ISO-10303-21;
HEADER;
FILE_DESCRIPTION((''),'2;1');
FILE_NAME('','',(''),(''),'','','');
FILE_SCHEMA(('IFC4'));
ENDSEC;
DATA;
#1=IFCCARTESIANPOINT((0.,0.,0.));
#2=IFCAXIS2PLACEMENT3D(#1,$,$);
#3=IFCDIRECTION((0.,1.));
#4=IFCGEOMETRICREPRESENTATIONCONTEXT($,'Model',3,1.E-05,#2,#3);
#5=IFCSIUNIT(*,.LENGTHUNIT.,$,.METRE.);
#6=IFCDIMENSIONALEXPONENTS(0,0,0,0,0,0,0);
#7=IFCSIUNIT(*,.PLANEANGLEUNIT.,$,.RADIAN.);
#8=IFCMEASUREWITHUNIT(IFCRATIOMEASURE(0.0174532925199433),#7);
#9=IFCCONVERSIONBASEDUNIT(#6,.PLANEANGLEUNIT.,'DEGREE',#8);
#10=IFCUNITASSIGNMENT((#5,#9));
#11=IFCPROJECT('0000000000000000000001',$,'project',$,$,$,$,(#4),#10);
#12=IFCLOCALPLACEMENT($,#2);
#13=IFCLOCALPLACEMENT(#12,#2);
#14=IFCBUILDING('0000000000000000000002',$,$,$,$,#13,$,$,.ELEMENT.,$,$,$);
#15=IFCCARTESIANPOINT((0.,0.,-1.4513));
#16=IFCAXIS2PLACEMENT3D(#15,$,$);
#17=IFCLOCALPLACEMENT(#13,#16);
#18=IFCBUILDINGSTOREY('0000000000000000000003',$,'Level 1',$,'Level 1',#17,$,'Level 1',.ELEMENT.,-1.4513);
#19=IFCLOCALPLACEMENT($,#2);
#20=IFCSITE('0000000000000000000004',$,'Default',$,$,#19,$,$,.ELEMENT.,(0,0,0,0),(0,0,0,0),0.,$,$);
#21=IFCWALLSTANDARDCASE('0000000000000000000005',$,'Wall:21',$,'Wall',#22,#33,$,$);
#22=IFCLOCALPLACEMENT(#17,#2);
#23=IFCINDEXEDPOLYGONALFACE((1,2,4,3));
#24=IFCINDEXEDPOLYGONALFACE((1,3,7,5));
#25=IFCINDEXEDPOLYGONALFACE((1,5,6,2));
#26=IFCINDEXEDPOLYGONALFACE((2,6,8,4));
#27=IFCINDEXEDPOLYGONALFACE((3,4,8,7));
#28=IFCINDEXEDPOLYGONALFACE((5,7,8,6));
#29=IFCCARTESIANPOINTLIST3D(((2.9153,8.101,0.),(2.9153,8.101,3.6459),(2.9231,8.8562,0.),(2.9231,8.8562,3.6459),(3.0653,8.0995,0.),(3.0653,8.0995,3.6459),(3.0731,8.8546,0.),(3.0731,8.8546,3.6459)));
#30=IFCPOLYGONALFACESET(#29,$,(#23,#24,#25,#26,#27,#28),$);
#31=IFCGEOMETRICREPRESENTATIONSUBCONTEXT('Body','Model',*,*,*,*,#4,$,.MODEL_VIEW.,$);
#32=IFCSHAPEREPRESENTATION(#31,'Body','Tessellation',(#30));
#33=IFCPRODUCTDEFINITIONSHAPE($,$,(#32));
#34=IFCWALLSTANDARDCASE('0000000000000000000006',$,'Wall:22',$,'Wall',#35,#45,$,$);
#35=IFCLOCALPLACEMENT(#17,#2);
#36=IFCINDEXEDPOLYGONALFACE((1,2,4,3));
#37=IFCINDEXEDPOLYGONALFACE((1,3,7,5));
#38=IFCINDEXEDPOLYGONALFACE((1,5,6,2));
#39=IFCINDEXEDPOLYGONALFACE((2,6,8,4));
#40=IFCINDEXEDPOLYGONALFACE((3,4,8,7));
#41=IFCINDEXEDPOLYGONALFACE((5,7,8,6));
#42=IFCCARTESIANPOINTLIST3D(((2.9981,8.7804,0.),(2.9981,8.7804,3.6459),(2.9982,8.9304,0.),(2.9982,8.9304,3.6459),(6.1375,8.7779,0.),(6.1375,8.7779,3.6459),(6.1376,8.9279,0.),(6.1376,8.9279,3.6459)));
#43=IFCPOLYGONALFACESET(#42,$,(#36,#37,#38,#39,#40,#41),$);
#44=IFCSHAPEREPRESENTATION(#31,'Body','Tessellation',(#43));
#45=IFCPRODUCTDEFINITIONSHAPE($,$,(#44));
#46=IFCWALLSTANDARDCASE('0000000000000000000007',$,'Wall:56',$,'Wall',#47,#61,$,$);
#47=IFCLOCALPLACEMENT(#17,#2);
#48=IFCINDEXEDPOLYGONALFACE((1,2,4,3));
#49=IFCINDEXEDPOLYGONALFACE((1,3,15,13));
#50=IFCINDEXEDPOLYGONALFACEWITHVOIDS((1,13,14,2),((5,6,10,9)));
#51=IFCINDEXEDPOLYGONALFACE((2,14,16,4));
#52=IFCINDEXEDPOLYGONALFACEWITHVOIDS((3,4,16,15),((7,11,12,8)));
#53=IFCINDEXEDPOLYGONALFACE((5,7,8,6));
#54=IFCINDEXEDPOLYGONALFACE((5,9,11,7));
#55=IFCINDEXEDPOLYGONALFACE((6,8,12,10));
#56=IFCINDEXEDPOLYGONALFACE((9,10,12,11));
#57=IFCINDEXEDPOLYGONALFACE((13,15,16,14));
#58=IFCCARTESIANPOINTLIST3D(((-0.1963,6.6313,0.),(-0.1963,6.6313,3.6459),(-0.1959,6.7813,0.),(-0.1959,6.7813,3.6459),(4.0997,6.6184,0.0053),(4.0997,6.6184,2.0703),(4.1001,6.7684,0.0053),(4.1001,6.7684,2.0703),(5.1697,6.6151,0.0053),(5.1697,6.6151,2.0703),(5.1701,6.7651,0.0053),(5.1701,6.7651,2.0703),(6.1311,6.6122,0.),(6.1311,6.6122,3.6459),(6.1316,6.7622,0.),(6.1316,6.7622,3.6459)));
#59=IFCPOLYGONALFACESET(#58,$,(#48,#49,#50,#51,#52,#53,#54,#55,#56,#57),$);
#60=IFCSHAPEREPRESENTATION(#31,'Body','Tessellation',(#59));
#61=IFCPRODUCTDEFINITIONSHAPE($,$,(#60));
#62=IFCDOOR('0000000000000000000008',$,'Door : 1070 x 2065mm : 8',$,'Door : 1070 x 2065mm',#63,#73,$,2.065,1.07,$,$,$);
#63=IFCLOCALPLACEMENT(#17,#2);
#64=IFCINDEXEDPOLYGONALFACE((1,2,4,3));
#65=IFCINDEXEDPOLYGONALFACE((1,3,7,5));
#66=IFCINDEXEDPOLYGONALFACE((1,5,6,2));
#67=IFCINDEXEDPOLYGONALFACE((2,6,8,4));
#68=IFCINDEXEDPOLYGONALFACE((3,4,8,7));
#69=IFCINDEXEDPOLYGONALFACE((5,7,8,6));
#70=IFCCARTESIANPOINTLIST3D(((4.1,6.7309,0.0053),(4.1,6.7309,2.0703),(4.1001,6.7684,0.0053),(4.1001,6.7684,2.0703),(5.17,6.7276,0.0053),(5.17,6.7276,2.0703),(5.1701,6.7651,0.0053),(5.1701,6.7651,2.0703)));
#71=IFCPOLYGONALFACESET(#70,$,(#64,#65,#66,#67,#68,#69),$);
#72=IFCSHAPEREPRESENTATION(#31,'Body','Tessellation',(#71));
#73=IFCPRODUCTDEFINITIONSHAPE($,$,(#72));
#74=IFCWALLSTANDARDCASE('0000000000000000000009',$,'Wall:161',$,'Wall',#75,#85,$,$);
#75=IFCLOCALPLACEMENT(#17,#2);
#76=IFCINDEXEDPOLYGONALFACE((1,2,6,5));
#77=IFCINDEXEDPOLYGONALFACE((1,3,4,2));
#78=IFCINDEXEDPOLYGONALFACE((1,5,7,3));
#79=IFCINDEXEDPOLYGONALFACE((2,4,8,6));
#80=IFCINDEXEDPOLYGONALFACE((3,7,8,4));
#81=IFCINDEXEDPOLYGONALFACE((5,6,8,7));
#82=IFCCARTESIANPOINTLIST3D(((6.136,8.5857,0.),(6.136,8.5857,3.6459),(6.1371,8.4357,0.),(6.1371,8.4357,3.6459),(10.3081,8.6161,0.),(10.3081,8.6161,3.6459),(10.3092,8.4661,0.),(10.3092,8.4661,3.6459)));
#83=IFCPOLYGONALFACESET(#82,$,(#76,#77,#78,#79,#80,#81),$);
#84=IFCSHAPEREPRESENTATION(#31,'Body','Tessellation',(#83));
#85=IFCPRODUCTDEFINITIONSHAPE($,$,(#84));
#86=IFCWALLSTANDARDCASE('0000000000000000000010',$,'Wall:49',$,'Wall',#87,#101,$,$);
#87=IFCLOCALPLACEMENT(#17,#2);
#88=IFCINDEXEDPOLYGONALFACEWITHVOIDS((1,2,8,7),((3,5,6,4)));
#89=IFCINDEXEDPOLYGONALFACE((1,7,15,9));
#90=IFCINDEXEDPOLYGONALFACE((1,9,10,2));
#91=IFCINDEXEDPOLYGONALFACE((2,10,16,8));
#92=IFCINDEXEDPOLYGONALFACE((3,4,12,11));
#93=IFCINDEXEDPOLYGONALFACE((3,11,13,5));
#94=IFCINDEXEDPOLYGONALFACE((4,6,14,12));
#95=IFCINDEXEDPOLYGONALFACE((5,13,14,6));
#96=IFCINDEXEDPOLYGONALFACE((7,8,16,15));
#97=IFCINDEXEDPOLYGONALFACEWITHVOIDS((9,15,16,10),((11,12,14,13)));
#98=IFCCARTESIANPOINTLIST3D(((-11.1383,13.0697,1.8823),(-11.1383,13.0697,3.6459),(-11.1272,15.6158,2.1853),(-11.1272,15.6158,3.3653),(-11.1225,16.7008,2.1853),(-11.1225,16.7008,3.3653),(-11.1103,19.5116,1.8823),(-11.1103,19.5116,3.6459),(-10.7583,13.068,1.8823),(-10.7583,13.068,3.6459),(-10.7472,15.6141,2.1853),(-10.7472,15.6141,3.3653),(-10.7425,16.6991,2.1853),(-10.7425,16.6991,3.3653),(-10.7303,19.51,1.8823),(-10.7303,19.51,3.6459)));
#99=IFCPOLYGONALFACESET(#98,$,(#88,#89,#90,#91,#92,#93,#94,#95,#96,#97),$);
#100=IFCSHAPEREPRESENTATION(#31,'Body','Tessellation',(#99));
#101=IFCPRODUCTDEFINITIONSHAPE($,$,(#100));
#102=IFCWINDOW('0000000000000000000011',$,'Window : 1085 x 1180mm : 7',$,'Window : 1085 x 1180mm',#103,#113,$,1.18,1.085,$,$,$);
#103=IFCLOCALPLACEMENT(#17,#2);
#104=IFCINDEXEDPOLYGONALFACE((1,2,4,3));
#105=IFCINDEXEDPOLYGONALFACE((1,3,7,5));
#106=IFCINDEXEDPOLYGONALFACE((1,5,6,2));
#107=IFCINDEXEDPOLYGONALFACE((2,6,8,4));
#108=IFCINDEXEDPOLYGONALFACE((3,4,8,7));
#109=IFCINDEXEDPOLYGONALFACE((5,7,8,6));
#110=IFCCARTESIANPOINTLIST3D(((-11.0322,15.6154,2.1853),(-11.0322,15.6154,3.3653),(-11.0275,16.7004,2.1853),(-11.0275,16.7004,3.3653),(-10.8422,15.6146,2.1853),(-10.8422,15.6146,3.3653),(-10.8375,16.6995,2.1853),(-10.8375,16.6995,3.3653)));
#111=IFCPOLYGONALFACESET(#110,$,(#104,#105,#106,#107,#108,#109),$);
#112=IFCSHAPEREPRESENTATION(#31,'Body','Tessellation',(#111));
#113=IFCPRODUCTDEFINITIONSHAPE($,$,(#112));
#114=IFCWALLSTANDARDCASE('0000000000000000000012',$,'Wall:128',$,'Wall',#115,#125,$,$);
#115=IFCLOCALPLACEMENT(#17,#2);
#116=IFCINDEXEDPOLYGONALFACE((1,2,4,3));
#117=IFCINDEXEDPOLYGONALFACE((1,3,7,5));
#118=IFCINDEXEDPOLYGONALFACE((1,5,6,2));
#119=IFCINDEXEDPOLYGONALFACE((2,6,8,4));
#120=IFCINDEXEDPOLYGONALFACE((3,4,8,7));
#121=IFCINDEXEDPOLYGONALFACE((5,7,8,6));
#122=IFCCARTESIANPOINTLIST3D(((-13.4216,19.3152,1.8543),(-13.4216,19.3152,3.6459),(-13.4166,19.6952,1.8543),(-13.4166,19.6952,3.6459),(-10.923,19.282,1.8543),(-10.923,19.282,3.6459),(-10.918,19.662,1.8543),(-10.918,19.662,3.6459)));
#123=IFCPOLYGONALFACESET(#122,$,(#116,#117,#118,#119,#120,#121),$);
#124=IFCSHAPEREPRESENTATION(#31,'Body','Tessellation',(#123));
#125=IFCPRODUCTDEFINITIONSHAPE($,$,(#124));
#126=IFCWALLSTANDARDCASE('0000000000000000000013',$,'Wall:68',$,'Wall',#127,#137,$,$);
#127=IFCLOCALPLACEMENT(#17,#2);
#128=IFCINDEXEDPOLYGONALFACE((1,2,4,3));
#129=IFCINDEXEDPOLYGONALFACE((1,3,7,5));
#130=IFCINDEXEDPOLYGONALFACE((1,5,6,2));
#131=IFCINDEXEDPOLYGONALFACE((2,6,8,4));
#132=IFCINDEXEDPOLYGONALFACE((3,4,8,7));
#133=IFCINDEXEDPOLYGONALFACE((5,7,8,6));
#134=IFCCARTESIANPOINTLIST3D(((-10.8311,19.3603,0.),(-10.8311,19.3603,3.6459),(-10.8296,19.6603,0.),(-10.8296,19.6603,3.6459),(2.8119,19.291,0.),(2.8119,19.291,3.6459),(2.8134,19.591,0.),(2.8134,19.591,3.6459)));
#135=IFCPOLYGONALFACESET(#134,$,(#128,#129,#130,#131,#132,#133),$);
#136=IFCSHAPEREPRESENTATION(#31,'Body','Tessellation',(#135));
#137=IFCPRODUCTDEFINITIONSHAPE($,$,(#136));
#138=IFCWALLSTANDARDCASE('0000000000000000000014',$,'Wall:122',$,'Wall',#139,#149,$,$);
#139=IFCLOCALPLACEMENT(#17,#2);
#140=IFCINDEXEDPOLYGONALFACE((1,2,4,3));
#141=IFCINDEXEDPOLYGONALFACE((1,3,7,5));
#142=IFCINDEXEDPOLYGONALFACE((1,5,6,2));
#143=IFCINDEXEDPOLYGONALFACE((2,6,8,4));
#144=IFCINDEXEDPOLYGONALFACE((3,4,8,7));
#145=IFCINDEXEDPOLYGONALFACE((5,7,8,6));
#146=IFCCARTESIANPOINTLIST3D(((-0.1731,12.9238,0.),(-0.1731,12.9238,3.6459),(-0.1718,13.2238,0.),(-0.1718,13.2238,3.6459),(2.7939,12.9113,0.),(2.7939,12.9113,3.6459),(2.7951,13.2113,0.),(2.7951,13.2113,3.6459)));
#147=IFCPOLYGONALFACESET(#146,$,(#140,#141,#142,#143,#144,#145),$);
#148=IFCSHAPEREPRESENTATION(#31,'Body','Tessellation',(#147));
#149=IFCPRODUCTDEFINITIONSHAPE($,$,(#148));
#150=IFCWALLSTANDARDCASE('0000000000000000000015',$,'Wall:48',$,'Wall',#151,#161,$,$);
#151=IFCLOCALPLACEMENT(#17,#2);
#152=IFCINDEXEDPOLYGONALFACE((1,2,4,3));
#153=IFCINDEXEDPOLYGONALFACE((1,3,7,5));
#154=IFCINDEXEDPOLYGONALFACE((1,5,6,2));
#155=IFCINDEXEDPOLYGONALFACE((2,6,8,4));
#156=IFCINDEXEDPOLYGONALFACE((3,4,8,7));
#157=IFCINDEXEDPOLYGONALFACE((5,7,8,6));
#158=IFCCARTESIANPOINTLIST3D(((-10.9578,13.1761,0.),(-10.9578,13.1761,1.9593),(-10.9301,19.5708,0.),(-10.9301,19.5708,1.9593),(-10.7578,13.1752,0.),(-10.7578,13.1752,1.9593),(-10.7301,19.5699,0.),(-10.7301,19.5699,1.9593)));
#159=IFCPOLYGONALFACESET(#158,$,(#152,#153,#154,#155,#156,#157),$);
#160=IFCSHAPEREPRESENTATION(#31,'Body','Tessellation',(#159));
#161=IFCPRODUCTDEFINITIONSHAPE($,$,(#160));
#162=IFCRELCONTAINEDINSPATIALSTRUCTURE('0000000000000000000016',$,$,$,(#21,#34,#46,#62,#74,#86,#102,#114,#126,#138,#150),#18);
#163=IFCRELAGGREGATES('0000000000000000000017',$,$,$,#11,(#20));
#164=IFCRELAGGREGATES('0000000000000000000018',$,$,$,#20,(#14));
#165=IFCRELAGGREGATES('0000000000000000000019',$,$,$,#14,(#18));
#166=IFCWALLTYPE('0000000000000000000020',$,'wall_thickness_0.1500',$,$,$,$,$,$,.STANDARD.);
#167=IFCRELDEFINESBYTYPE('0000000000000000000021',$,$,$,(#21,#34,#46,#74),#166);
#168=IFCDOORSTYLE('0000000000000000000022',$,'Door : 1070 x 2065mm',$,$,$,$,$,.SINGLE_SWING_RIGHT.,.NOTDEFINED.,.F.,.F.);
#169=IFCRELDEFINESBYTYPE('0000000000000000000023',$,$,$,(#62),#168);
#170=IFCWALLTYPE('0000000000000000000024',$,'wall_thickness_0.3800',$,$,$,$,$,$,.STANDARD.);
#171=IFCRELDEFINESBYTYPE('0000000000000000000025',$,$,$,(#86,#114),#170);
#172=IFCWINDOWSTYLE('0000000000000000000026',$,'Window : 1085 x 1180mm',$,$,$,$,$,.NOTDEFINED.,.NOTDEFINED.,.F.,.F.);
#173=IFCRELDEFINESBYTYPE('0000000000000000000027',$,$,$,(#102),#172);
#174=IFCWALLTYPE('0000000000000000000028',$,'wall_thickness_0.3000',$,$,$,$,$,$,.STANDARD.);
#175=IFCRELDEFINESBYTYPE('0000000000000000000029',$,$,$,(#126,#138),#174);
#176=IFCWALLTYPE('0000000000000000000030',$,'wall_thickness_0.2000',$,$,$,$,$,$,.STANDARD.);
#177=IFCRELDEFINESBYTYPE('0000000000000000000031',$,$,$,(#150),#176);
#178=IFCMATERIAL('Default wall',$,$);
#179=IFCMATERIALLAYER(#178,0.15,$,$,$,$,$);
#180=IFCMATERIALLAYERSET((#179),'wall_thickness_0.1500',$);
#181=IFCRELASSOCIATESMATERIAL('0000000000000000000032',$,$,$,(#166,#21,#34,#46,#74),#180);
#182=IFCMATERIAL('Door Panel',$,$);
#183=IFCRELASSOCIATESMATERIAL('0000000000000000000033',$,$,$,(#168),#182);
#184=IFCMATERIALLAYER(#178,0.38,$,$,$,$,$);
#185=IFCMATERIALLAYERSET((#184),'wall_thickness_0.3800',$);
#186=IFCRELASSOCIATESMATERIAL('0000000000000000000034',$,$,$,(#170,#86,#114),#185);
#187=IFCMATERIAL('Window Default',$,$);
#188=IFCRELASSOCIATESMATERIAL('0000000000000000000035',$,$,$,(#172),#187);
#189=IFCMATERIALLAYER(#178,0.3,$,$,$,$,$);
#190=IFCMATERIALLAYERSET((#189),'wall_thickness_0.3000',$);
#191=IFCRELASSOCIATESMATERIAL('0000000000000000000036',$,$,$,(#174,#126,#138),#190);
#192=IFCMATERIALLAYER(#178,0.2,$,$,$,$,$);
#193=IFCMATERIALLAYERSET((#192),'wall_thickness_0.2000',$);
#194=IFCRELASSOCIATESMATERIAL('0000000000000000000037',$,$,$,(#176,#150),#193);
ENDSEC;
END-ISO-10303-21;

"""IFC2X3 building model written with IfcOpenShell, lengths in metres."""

from ifc_helpers import new_model, entity, si_unit, converted_unit, direction, frame, frame_2d, origin, origin_2d_with_axis, place, context, subcontext, project, spatial, polyline, rectangle, outline, extrude, source, transform, mapped, material, layer, layer_set, layer_usage, type_object, type_shapes, element, fill, save


model = new_model("IFC2X3")

# Units and contexts
model_context = context("Model", 3, precision=1e-05, world=origin(), true_north=direction((0.0, 1.0)))
body_context = subcontext(model_context, "Body", "Model", "MODEL_VIEW")
ifc_project = project(units=[si_unit("LENGTHUNIT", "METRE"), converted_unit("PLANEANGLEUNIT", "DEGREE", entity("IfcRatioMeasure", 0.0174532925199433), si_unit("PLANEANGLEUNIT", "RADIAN"), dimensions=[0, 0, 0, 0, 0, 0, 0])], contexts=[model_context])

# Site, building, storey
site_placement = place(None, origin())
site = spatial("IfcSite", under=ifc_project, at=site_placement, Name="Default", CompositionType="ELEMENT", RefLatitude=(0, 0, 0, 0), RefLongitude=(0, 0, 0, 0), RefElevation=0.0)
placement_1 = place(None, origin())
building_placement = place(placement_1, origin())
building = spatial("IfcBuilding", under=site, at=building_placement, CompositionType="ELEMENT")
storey_placement = place(building_placement, frame((0.0, 0.0, -1.4513)))
storey = spatial("IfcBuildingStorey", under=building, at=storey_placement, Name="Level 1", ObjectType="Level 1", LongName="Level 1", CompositionType="ELEMENT", Elevation=-1.4513)

# Walls
ifc_material_1 = material(Name="Default wall")
ifc_layer_1 = layer(ifc_material_1, 0.15)
ifc_layer_set_1 = layer_set([ifc_layer_1], Name="wall_thickness_0.1500")
ifc_layer_usage_1 = layer_usage(ifc_layer_set_1, "AXIS2", "POSITIVE", -0.075)
wall_type_1 = type_object("IfcWallType", Name="wall_thickness_0.1500", PredefinedType="STANDARD", material=ifc_layer_set_1)
wall_1_placement = place(storey_placement, frame((2.9981, 8.8554, 0.0), z_axis=(0.0, 0.0, 1.0), x_axis=(-0.010337, -0.999947, 0.0)))
element("IfcWallStandardCase", 1, at=wall_1_placement, inside=storey, type_object=wall_type_1, material=ifc_layer_usage_1, Name="Wall:21", ObjectType="Wall", context=body_context, shape_type="SweptSolid", body=[
    extrude(outline(polyline([(0.7552, -0.075), (0.7552, 0.075), (0.0, 0.075), (0.0, -0.075), (0.7552, -0.075)])), origin(), (0.0, 0.0, 1.0), 3.6459),
])
wall_2_placement = place(storey_placement, frame((2.9981, 8.8554, 0.0), z_axis=(0.0, 0.0, 1.0), x_axis=(1.0, -0.000796, 0.0)))
element("IfcWallStandardCase", 2, at=wall_2_placement, inside=storey, type_object=wall_type_1, material=ifc_layer_usage_1, Name="Wall:22", ObjectType="Wall", context=body_context, shape_type="SweptSolid", body=[
    extrude(outline(polyline([(3.1394, -0.075), (3.1394, 0.075), (0.0, 0.075), (0.0, -0.075), (3.1394, -0.075)])), origin(), (0.0, 0.0, 1.0), 3.6459),
])

# Wall, opening, door
wall_3_placement = place(storey_placement, frame((-0.1961, 6.7063, 0.0), z_axis=(0.0, 0.0, 1.0), x_axis=(0.999995, -0.003016, 0.0)))
wall_3 = element("IfcWallStandardCase", 3, at=wall_3_placement, inside=storey, type_object=wall_type_1, material=ifc_layer_usage_1, Name="Wall:56", ObjectType="Wall", context=body_context, shape_type="SweptSolid", body=[
    extrude(outline(polyline([(6.3275, -0.075), (6.3275, 0.075), (0.0, 0.075), (0.0, -0.075), (6.3275, -0.075)])), origin(), (0.0, 0.0, 1.0), 3.6459),
])
opening_1_placement = place(wall_3_placement, frame((4.296, -0.075, 0.0053)))
opening_1 = element("IfcOpeningElement", 4, at=opening_1_placement, cuts=wall_3, ObjectType="Opening", context=body_context, shape_type="SweptSolid", body=[
    extrude(rectangle(XDim=1.07, YDim=2.065, at=frame_2d((1.0325, 0.535), x_axis=(0.0, 1.0))), frame((0.0, 0.0, 0.0), z_axis=(0.0, 1.0, 0.0), x_axis=(0.0, 0.0, 1.0)), (0.0, 0.0, 1.0), 0.15),
])
ifc_material_2 = material(Name="Door Panel")
door_style = type_object("IfcDoorStyle", Name="Door : 1070 x 2065mm", ConstructionType="NOTDEFINED", OperationType="SINGLE_SWING_RIGHT", ParameterTakesPrecedence=False, Sizeable=False, material=ifc_material_2)
shared_shape_1 = source(origin(), body_context, "Body", "SweptSolid", [
    extrude(rectangle(XDim=0.0375, YDim=1.07, at=origin_2d_with_axis()), frame((0.535, 0.1313, 0.0), z_axis=(0.0, 0.0, 1.0), x_axis=(0.0, 1.0, 0.0)), (0.0, 0.0, 1.0), 2.065),
])
type_shapes(door_style, [shared_shape_1])
door_placement = place(opening_1_placement, origin())
door = element("IfcDoor", 5, at=door_placement, inside=storey, type_object=door_style, Name="Door : 1070 x 2065mm : 8", ObjectType="Door : 1070 x 2065mm", OverallHeight=2.065, OverallWidth=1.07, context=body_context, shape_type="MappedRepresentation", body=[
    mapped(shared_shape_1, transform((0.0, 0.0, 0.0), scale=1.0)),
])
fill(opening_1, door)

# Wall
wall_4_placement = place(storey_placement, frame((6.1366, 8.5107, 0.0), z_axis=(0.0, 0.0, 1.0), x_axis=(0.999974, 0.007273, 0.0)))
element("IfcWallStandardCase", 6, at=wall_4_placement, inside=storey, type_object=wall_type_1, material=ifc_layer_usage_1, Name="Wall:161", ObjectType="Wall", context=body_context, shape_type="SweptSolid", body=[
    extrude(outline(polyline([(4.1722, -0.075), (4.1722, 0.075), (0.0, 0.075), (0.0, -0.075), (4.1722, -0.075)])), origin(), (0.0, 0.0, 1.0), 3.6459),
])

# Wall, opening, window
ifc_layer_2 = layer(ifc_material_1, 0.38)
ifc_layer_set_2 = layer_set([ifc_layer_2], Name="wall_thickness_0.3800")
ifc_layer_usage_2 = layer_usage(ifc_layer_set_2, "AXIS2", "POSITIVE", -0.19)
wall_type_2 = type_object("IfcWallType", Name="wall_thickness_0.3800", PredefinedType="STANDARD", material=ifc_layer_set_2)
placement_2 = place(building_placement, frame((0.0, 0.0, 0.431)))
wall_5_placement = place(placement_2, frame((-10.9203, 19.5108, 0.0), z_axis=(0.0, 0.0, 1.0), x_axis=(-0.004341, -0.999991, 0.0)))
wall_5 = element("IfcWallStandardCase", 7, at=wall_5_placement, inside=storey, type_object=wall_type_2, material=ifc_layer_usage_2, Name="Wall:49", ObjectType="Wall", context=body_context, shape_type="SweptSolid", body=[
    extrude(outline(polyline([(6.442, -0.19), (6.442, 0.19), (0.0, 0.19), (0.0, -0.19), (6.442, -0.19)])), origin(), (0.0, 0.0, 1.0), 1.7636),
])
opening_2_placement = place(wall_5_placement, frame((2.8109, -0.19, 0.303)))
opening_2 = element("IfcOpeningElement", 8, at=opening_2_placement, cuts=wall_5, ObjectType="Opening", context=body_context, shape_type="SweptSolid", body=[
    extrude(rectangle(XDim=1.085, YDim=1.18, at=frame_2d((0.59, 0.5425), x_axis=(0.0, 1.0))), frame((0.0, 0.0, 0.0), z_axis=(0.0, 1.0, 0.0), x_axis=(0.0, 0.0, 1.0)), (0.0, 0.0, 1.0), 0.38),
])
ifc_material_3 = material(Name="Window Default")
window_style_1 = type_object("IfcWindowStyle", Name="Window : 1085 x 1180mm", ConstructionType="NOTDEFINED", OperationType="NOTDEFINED", ParameterTakesPrecedence=False, Sizeable=False, material=ifc_material_3)
shared_shape_2 = source(origin(), body_context, "Body", "SweptSolid", [
    extrude(rectangle(XDim=0.19, YDim=1.085, at=origin_2d_with_axis()), frame((0.5425, 0.19, 0.0), z_axis=(0.0, 0.0, 1.0), x_axis=(0.0, 1.0, 0.0)), (0.0, 0.0, 1.0), 1.18),
])
type_shapes(window_style_1, [shared_shape_2])
window_1_placement = place(opening_2_placement, origin())
window_1 = element("IfcWindow", 9, at=window_1_placement, inside=storey, type_object=window_style_1, Name="Window : 1085 x 1180mm : 7", ObjectType="Window : 1085 x 1180mm", OverallHeight=1.18, OverallWidth=1.085, context=body_context, shape_type="MappedRepresentation", body=[
    mapped(shared_shape_2, transform((0.0, 0.0, 0.0), scale=1.0)),
])
fill(opening_2, window_1)

# Walls
placement_3 = place(building_placement, frame((0.0, 0.0, 0.403)))
wall_6_placement = place(placement_3, frame((-13.4191, 19.5052, 0.0), z_axis=(0.0, 0.0, 1.0), x_axis=(0.999912, -0.013278, 0.0)))
element("IfcWallStandardCase", 10, at=wall_6_placement, inside=storey, type_object=wall_type_2, material=ifc_layer_usage_2, Name="Wall:128", ObjectType="Wall", context=body_context, shape_type="SweptSolid", body=[
    extrude(outline(polyline([(2.4988, -0.19), (2.4988, 0.19), (0.0, 0.19), (0.0, -0.19), (2.4988, -0.19)])), origin(), (0.0, 0.0, 1.0), 1.7916),
])
ifc_layer_3 = layer(ifc_material_1, 0.3)
ifc_layer_set_3 = layer_set([ifc_layer_3], Name="wall_thickness_0.3000")
ifc_layer_usage_3 = layer_usage(ifc_layer_set_3, "AXIS2", "POSITIVE", -0.15)
wall_type_3 = type_object("IfcWallType", Name="wall_thickness_0.3000", PredefinedType="STANDARD", material=ifc_layer_set_3)
wall_7_placement = place(storey_placement, frame((-10.8303, 19.5103, 0.0), z_axis=(0.0, 0.0, 1.0), x_axis=(0.999987, -0.005085, 0.0)))
element("IfcWallStandardCase", 11, at=wall_7_placement, inside=storey, type_object=wall_type_3, material=ifc_layer_usage_3, Name="Wall:68", ObjectType="Wall", context=body_context, shape_type="SweptSolid", body=[
    extrude(outline(polyline([(13.6431, -0.15), (13.6431, 0.15), (0.0, 0.15), (0.0, -0.15), (13.6431, -0.15)])), origin(), (0.0, 0.0, 1.0), 3.6459),
])
wall_8_placement = place(storey_placement, frame((-0.1724, 13.0738, 0.0), z_axis=(0.0, 0.0, 1.0), x_axis=(0.999991, -0.004216, 0.0)))
element("IfcWallStandardCase", 12, at=wall_8_placement, inside=storey, type_object=wall_type_3, material=ifc_layer_usage_3, Name="Wall:122", ObjectType="Wall", context=body_context, shape_type="SweptSolid", body=[
    extrude(outline(polyline([(2.967, -0.15), (2.967, 0.15), (0.0, 0.15), (0.0, -0.15), (2.967, -0.15)])), origin(), (0.0, 0.0, 1.0), 3.6459),
])
ifc_layer_4 = layer(ifc_material_1, 0.2)
ifc_layer_set_4 = layer_set([ifc_layer_4], Name="wall_thickness_0.2000")
ifc_layer_usage_4 = layer_usage(ifc_layer_set_4, "AXIS2", "POSITIVE", -0.1)
wall_type_4 = type_object("IfcWallType", Name="wall_thickness_0.2000", PredefinedType="STANDARD", material=ifc_layer_set_4)
wall_9_placement = place(storey_placement, frame((-10.8301, 19.5703, 0.0), z_axis=(0.0, 0.0, 1.0), x_axis=(-0.004341, -0.999991, 0.0)))
element("IfcWallStandardCase", 13, at=wall_9_placement, inside=storey, type_object=wall_type_4, material=ifc_layer_usage_4, Name="Wall:48", ObjectType="Wall", context=body_context, shape_type="SweptSolid", body=[
    extrude(outline(polyline([(6.3947, -0.1), (6.3947, 0.1), (0.0, 0.1), (0.0, -0.1), (6.3947, -0.1)])), origin(), (0.0, 0.0, 1.0), 1.9593),
])

save(model, "model.ifc")
